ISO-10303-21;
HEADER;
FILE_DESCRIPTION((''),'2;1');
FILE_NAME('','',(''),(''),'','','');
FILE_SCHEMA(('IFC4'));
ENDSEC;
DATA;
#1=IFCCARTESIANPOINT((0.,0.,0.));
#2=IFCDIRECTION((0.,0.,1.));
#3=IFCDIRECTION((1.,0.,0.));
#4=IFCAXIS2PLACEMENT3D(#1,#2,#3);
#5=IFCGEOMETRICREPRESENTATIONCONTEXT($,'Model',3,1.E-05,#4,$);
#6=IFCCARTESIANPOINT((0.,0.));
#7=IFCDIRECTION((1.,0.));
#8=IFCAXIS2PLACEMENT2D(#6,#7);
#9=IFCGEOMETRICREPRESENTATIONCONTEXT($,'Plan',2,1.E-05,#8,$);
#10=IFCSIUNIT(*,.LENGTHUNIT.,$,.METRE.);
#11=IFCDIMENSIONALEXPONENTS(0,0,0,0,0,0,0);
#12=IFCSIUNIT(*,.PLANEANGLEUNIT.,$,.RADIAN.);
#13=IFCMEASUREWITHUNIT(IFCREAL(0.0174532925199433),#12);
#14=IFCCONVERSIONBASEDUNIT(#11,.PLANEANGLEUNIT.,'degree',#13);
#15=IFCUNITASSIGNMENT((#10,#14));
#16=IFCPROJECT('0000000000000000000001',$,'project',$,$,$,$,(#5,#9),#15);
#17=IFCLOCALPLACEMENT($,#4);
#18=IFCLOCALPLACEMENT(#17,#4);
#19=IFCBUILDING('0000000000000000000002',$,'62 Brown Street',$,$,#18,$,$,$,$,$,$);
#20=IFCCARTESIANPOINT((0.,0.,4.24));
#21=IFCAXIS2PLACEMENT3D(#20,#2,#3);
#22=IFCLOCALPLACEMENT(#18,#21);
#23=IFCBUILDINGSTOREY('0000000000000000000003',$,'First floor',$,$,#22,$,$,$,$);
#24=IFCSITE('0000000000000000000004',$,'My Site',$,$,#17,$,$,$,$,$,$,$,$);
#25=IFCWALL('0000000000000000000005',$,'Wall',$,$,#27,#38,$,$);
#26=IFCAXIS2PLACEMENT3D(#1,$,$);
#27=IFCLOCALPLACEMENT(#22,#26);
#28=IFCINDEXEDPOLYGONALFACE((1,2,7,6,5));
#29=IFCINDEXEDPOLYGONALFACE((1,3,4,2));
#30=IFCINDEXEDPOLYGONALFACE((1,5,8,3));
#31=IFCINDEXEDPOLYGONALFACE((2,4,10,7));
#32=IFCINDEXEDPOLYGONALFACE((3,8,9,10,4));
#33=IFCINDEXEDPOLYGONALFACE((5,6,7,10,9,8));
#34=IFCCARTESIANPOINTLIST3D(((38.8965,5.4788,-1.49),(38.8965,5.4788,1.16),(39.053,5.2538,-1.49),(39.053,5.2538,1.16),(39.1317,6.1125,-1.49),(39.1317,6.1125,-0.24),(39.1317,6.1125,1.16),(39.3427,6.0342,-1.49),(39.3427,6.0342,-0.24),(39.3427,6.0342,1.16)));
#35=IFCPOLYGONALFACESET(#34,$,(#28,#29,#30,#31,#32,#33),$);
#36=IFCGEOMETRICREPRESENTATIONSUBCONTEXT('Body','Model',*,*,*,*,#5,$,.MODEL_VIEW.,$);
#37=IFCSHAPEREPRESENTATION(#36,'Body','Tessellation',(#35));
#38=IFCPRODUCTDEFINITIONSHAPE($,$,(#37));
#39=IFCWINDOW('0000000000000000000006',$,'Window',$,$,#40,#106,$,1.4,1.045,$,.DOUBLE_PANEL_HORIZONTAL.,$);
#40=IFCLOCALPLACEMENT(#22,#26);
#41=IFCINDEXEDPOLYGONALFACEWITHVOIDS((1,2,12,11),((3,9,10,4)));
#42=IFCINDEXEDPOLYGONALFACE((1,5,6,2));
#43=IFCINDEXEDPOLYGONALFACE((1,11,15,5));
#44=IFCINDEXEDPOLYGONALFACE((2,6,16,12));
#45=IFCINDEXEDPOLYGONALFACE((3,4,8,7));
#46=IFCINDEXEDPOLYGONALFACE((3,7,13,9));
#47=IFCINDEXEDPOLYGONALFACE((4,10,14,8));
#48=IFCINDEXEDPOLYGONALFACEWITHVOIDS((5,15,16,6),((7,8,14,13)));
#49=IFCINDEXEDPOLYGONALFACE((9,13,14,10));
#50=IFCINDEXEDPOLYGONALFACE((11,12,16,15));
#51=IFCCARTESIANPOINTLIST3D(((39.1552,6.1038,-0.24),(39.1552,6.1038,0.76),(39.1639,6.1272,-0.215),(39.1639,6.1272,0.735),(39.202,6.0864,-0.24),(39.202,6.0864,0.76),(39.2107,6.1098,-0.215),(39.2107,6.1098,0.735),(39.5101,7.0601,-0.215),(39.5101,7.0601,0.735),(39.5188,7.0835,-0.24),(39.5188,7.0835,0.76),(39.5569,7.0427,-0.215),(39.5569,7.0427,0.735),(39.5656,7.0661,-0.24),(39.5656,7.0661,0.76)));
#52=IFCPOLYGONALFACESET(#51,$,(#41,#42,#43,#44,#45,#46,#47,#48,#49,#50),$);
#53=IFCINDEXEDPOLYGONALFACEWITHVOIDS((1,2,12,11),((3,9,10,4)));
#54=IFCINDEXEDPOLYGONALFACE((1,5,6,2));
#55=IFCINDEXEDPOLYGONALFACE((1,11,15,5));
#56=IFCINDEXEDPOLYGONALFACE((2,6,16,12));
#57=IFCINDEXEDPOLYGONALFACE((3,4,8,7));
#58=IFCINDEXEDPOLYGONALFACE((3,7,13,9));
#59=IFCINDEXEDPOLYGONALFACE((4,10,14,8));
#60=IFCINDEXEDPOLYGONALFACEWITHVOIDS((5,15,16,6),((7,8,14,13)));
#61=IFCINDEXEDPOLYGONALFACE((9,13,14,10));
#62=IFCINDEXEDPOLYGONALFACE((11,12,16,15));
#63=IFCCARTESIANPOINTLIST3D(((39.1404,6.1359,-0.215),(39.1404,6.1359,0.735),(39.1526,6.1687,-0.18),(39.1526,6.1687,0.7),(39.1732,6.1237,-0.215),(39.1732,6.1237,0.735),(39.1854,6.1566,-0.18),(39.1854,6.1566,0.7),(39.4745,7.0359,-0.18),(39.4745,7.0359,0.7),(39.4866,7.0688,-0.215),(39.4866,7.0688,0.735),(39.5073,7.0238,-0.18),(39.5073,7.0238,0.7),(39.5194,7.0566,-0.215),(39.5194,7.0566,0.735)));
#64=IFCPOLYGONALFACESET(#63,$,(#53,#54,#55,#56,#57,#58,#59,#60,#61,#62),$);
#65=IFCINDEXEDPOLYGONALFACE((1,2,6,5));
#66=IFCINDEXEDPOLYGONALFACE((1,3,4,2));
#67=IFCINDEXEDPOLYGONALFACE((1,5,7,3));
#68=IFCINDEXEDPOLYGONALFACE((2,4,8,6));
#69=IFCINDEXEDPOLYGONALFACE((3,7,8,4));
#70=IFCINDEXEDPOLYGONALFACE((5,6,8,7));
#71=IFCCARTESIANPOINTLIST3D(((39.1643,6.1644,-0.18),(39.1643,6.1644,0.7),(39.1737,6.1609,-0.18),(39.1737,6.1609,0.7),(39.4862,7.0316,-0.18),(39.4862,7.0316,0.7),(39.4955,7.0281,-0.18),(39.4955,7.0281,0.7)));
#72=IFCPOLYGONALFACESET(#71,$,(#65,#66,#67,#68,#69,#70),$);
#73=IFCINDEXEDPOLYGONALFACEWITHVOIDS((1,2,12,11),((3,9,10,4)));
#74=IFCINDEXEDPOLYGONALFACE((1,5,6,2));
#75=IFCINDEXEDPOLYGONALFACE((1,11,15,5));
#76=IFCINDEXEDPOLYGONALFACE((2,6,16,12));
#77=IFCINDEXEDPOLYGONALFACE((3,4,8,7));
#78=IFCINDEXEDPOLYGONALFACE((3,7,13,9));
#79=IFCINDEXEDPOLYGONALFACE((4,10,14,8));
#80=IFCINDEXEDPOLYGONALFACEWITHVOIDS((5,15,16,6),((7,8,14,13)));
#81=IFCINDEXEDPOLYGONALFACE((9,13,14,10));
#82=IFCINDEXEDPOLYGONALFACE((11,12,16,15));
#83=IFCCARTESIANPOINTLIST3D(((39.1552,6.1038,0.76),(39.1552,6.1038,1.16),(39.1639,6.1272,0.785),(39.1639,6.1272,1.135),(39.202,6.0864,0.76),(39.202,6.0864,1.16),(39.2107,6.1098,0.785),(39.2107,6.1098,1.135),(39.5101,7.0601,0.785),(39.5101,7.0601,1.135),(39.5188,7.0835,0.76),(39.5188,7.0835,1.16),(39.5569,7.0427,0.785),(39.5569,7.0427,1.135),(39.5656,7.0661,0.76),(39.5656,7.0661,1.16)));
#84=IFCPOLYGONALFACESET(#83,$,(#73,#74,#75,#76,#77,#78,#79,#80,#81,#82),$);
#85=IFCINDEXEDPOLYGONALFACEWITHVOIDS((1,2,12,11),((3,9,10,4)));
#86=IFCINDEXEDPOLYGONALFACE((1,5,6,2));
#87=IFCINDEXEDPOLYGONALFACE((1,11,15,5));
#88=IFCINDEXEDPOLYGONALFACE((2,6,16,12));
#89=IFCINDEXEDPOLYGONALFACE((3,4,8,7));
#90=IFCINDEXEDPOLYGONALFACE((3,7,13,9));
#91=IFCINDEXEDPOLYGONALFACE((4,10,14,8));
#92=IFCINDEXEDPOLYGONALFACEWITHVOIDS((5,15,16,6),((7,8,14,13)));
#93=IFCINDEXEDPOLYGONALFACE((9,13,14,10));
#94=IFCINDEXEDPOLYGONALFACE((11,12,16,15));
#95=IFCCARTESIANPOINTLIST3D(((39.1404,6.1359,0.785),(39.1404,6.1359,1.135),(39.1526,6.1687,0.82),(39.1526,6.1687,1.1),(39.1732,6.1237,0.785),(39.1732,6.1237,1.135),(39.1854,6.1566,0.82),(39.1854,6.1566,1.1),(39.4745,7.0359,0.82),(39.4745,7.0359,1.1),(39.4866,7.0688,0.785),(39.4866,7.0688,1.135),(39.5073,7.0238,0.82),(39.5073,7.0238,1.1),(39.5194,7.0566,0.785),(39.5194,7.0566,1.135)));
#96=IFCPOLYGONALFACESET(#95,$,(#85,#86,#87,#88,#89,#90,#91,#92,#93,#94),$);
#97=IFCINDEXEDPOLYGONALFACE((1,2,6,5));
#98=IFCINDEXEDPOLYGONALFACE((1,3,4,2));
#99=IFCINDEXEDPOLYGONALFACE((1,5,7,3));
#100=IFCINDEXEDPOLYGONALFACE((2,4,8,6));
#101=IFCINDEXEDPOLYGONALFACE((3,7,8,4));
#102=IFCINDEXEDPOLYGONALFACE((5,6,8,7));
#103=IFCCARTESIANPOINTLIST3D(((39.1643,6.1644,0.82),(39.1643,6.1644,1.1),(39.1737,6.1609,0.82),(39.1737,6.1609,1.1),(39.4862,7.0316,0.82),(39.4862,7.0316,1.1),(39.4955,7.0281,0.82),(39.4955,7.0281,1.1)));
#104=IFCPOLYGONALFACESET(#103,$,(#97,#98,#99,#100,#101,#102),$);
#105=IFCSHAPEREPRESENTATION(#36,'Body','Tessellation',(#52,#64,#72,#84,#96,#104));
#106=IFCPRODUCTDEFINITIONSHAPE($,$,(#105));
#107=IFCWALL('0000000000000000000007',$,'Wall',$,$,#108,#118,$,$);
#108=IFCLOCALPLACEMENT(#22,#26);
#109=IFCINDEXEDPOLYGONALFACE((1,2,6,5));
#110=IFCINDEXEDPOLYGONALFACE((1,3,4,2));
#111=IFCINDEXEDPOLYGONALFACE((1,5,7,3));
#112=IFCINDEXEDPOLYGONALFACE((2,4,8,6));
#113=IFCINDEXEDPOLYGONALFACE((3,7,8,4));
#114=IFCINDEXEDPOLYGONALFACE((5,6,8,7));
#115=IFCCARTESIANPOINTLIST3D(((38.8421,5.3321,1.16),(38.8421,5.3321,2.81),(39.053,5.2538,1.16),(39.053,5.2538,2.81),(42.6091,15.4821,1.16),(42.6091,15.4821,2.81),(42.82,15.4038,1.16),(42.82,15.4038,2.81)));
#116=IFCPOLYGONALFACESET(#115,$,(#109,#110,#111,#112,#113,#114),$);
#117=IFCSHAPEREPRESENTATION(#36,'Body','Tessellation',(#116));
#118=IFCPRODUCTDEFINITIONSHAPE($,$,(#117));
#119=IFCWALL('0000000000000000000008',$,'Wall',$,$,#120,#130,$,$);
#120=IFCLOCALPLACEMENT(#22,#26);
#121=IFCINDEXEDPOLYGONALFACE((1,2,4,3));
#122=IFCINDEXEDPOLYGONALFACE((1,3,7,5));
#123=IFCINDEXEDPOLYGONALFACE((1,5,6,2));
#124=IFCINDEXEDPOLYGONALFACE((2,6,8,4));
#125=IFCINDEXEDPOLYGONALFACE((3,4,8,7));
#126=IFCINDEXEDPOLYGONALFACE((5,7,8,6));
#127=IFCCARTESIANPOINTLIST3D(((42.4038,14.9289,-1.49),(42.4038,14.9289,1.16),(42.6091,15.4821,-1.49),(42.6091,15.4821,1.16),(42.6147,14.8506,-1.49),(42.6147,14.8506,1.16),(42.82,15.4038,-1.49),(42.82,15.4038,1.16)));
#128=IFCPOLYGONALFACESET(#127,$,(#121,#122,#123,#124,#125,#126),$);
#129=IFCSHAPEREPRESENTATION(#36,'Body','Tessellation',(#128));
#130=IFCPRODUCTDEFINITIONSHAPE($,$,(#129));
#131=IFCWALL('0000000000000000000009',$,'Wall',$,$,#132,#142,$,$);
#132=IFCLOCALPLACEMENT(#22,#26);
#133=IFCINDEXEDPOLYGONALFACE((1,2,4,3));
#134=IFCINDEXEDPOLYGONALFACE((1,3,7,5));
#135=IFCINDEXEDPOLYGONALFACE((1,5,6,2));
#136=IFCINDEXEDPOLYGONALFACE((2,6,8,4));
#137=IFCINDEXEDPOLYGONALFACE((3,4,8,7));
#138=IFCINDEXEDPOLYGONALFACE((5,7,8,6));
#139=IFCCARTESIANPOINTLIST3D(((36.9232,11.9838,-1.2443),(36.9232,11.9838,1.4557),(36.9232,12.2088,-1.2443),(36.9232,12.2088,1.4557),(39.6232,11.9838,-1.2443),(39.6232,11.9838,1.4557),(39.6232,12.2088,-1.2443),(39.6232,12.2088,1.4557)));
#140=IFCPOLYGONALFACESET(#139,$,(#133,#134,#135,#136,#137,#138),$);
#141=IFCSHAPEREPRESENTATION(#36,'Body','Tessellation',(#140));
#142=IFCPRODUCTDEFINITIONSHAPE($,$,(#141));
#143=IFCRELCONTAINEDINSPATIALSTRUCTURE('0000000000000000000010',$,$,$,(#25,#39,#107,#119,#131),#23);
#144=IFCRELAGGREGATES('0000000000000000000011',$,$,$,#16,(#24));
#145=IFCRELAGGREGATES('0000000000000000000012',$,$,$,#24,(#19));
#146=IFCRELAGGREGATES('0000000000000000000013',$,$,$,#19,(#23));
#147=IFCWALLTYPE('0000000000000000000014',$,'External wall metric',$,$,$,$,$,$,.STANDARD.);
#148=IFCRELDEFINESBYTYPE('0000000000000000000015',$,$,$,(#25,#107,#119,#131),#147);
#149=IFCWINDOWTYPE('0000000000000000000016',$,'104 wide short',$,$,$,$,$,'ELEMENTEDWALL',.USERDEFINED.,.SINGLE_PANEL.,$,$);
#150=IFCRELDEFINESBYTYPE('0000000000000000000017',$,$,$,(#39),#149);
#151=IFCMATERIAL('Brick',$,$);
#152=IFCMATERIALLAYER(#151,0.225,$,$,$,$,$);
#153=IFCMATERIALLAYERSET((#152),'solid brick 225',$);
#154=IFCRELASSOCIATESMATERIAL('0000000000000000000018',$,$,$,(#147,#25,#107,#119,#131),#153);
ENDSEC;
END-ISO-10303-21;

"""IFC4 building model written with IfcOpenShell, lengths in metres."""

from ifc_helpers import new_model, entity, si_unit, converted_unit, frame, origin_with_axes, origin_2d_with_axis, place, context, subcontext, project, spatial, line, indexed_curve, outline, extrude, clip, halfspace, shape, source, transform, mapped, material, layer, layer_set, layer_usage, type_object, type_shapes, element, fill, save


model = new_model("IFC4")

# Units and contexts
model_context = context("Model", 3, precision=1e-05, world=origin_with_axes())
plan_context = context("Plan", 2, precision=1e-05, world=origin_2d_with_axis())
body_context_1 = subcontext(model_context, "Body", "Model", "MODEL_VIEW")
body_context_2 = subcontext(plan_context, "Body", "Plan", "PLAN_VIEW")
ifc_project = project(units=[si_unit("LENGTHUNIT", "METRE"), converted_unit("PLANEANGLEUNIT", "degree", entity("IfcReal", 0.0174532925199433), si_unit("PLANEANGLEUNIT", "RADIAN"), dimensions=[0, 0, 0, 0, 0, 0, 0])], contexts=[model_context, plan_context])

# Site, building, storey
site_placement = place(None, origin_with_axes())
site = spatial("IfcSite", under=ifc_project, at=site_placement, Name="My Site")
building_placement = place(site_placement, origin_with_axes())
building = spatial("IfcBuilding", under=site, at=building_placement, Name="62 Brown Street")
storey_placement = place(building_placement, frame((0.0, 0.0, 4.24), z_axis=(0.0, 0.0, 1.0), x_axis=(1.0, 0.0, 0.0)))
storey = spatial("IfcBuildingStorey", under=building, at=storey_placement, Name="First floor")

# Shared definitions
ifc_material_1 = material(Name="Brick")
ifc_layer_1 = layer(ifc_material_1, 0.225)
ifc_layer_set_1 = layer_set([ifc_layer_1], Name="solid brick 225")
wall_type_1 = type_object("IfcWallType", Name="External wall metric", PredefinedType="STANDARD", material=ifc_layer_set_1)

# Wall, opening, window
ifc_layer_usage_1 = layer_usage(ifc_layer_set_1, "AXIS2", "POSITIVE", 0.0)
wall_1_placement = place(storey_placement, frame((39.024, 5.1755, -1.49), z_axis=(0.0, 0.0, 1.0), x_axis=(0.347944, 0.937515, 0.0)))
wall_1 = element("IfcWall", 1, at=wall_1_placement, inside=storey, type_object=wall_type_1, material=ifc_layer_usage_1, Name="Wall", context=body_context_1, shape_type="Clipping", body=[
    clip(extrude(outline(indexed_curve([(0.0, 0.0), (0.0, 0.225), (0.9159, 0.225), (0.9159, 0.0), (0.0, 0.0)], self_intersect=False)), origin_with_axes(), (0.0, 0.0, 1.0), 2.65), halfspace(frame((0.0835, 0.0, -2.75), z_axis=(-0.596248, 0.414701, 0.0), x_axis=(0.156491, 0.224999, 0.0)), False)),
])
shared_shape_1 = source(origin_with_axes(), body_context_1, "Body", "SweptSolid", [
    extrude(outline(indexed_curve([(0.0, 0.0), (1.045, 0.0), (1.045, 1.4), (0.0, 1.4)], segments=[line(1, 2, 3, 4, 1)])), frame((0.0, -0.1, 0.0), z_axis=(0.0, -1.0, 0.0), x_axis=(1.0, 0.0, 0.0)), (0.0, 0.0, -1.0), 0.425),
])
opening_1_placement = place(wall_1_placement, frame((0.9159, 0.0, 1.25), z_axis=(0.0, 0.0, 1.0), x_axis=(1.0, 0.0, 0.0)))
opening_1 = element("IfcOpeningElement", 2, at=opening_1_placement, cuts=wall_1, PredefinedType="OPENING", context=body_context_1, shape_type="MappedRepresentation", body=[
    mapped(shared_shape_1, transform((0.0, 0.0, 0.0), x_axis=(1.0, 0.0, 0.0), y_axis=(0.0, 1.0, 0.0), z_axis=(0.0, 0.0, 1.0), scale=1.0)),
])
window_type_1 = type_object("IfcWindowType", Name="104 wide short", ElementType="ELEMENTEDWALL", PartitioningType="SINGLE_PANEL", PredefinedType="USERDEFINED")
shared_shape_2 = source(origin_with_axes(), body_context_1, "Body", "SweptSolid", [
    extrude(outline(indexed_curve([(0.0, 0.0), (1.045, 0.0), (1.045, 1.0), (0.0, 1.0)], segments=[line(1, 2, 3, 4, 1)]), holes=[indexed_curve([(0.025, 0.025), (1.02, 0.025), (1.02, 0.975), (0.025, 0.975)], segments=[line(1, 2, 3, 4, 1)])]), frame((0.0, 0.15, 0.0), z_axis=(0.0, -1.0, 0.0), x_axis=(1.0, 0.0, 0.0)), (0.0, 0.0, -1.0), 0.05),
    extrude(outline(indexed_curve([(0.0, 0.0), (0.995, 0.0), (0.995, 0.95), (0.0, 0.95)], segments=[line(1, 2, 3, 4, 1)]), holes=[indexed_curve([(0.035, 0.035), (0.96, 0.035), (0.96, 0.915), (0.035, 0.915)], segments=[line(1, 2, 3, 4, 1)])]), frame((0.025, 0.19, 0.025), z_axis=(0.0, -1.0, 0.0), x_axis=(1.0, 0.0, 0.0)), (0.0, 0.0, -1.0), 0.035),
    extrude(outline(indexed_curve([(0.035, 0.035), (0.96, 0.035), (0.96, 0.915), (0.035, 0.915)], segments=[line(1, 2, 3, 4, 1)])), frame((0.025, 0.2025, 0.025), z_axis=(0.0, -1.0, 0.0), x_axis=(1.0, 0.0, 0.0)), (0.0, 0.0, -1.0), 0.01),
    extrude(outline(indexed_curve([(0.0, 0.0), (1.045, 0.0), (1.045, 0.4), (0.0, 0.4)], segments=[line(1, 2, 3, 4, 1)]), holes=[indexed_curve([(0.025, 0.025), (1.02, 0.025), (1.02, 0.375), (0.025, 0.375)], segments=[line(1, 2, 3, 4, 1)])]), frame((0.0, 0.15, 1.0), z_axis=(0.0, -1.0, 0.0), x_axis=(1.0, 0.0, 0.0)), (0.0, 0.0, -1.0), 0.05),
    extrude(outline(indexed_curve([(0.0, 0.0), (0.995, 0.0), (0.995, 0.35), (0.0, 0.35)], segments=[line(1, 2, 3, 4, 1)]), holes=[indexed_curve([(0.035, 0.035), (0.96, 0.035), (0.96, 0.315), (0.035, 0.315)], segments=[line(1, 2, 3, 4, 1)])]), frame((0.025, 0.19, 1.025), z_axis=(0.0, -1.0, 0.0), x_axis=(1.0, 0.0, 0.0)), (0.0, 0.0, -1.0), 0.035),
    extrude(outline(indexed_curve([(0.035, 0.035), (0.96, 0.035), (0.96, 0.315), (0.035, 0.315)], segments=[line(1, 2, 3, 4, 1)])), frame((0.025, 0.2025, 1.025), z_axis=(0.0, -1.0, 0.0), x_axis=(1.0, 0.0, 0.0)), (0.0, 0.0, -1.0), 0.01),
])
shared_shape_3 = source(origin_with_axes(), body_context_2, "Body", "Curve2D", [
    entity("IfcIndexedPolyCurve", entity("IfcCartesianPointList2D", [[0.025, 0.15], [1.02, 0.15]])),
    entity("IfcIndexedPolyCurve", entity("IfcCartesianPointList2D", [[0.0, 0.2], [0.025, 0.2], [0.025, 0.15], [0.0, 0.15]]), [entity("IfcLineIndex", [1, 2, 3, 4, 1])]),
    entity("IfcIndexedPolyCurve", entity("IfcCartesianPointList2D", [[1.045, 0.2], [1.02, 0.2], [1.02, 0.15], [1.045, 0.15]]), [entity("IfcLineIndex", [1, 2, 3, 4, 1])]),
    entity("IfcIndexedPolyCurve", entity("IfcCartesianPointList2D", [[0.025, 0.19], [0.06, 0.19], [0.06, 0.225], [0.025, 0.225]]), [entity("IfcLineIndex", [1, 2, 3, 4, 1])]),
    entity("IfcIndexedPolyCurve", entity("IfcCartesianPointList2D", [[1.02, 0.19], [0.985, 0.19], [0.985, 0.225], [1.02, 0.225]]), [entity("IfcLineIndex", [1, 2, 3, 4, 1])]),
    entity("IfcIndexedPolyCurve", entity("IfcCartesianPointList2D", [[0.06, 0.19], [0.985, 0.19]])),
    entity("IfcIndexedPolyCurve", entity("IfcCartesianPointList2D", [[0.06, 0.225], [0.985, 0.225]])),
    entity("IfcIndexedPolyCurve", entity("IfcCartesianPointList2D", [[0.06, 0.2075], [0.985, 0.2075]])),
])
type_shapes(window_type_1, [shared_shape_2, shared_shape_3])
window_1_placement = place(opening_1_placement, frame((0.0, 0.0, 0.0), z_axis=(0.0, 0.0, 1.0), x_axis=(1.0, 0.0, 0.0)))
window_1 = element("IfcWindow", 3, at=window_1_placement, inside=storey, type_object=window_type_1, Name="Window", OverallHeight=1.4, OverallWidth=1.045, PartitioningType="DOUBLE_PANEL_HORIZONTAL", shapes=[
    shape(body_context_1, "Body", "MappedRepresentation", [mapped(shared_shape_2, transform((0.0, 0.0, 0.0), x_axis=(1.0, 0.0, 0.0), y_axis=(0.0, 1.0, 0.0), z_axis=(0.0, 0.0, 1.0), scale=1.0))]),
    shape(body_context_2, "Body", "MappedRepresentation", [mapped(shared_shape_3, transform((0.0, 0.0, 0.0), x_axis=(1.0, 0.0, 0.0), y_axis=(0.0, 1.0, 0.0), z_axis=(0.0, 0.0, 1.0), scale=1.0))]),
])
fill(opening_1, window_1)

# Walls
ifc_layer_usage_2 = layer_usage(ifc_layer_set_1, "AXIS2", "POSITIVE", 0.0)
wall_2_placement = place(storey_placement, frame((39.053, 5.2538, 1.16), z_axis=(0.0, 0.0, 1.0), x_axis=(0.347944, 0.937515, 0.0)))
element("IfcWall", 4, at=wall_2_placement, inside=storey, type_object=wall_type_1, material=ifc_layer_usage_2, Name="Wall", context=body_context_1, shape_type="SweptSolid", body=[
    extrude(outline(indexed_curve([(0.0, 0.0), (0.0, 0.225), (10.8265, 0.225), (10.8265, 0.0), (0.0, 0.0)], self_intersect=False)), origin_with_axes(), (0.0, 0.0, 1.0), 1.65),
])
ifc_layer_usage_3 = layer_usage(ifc_layer_set_1, "AXIS2", "POSITIVE", 0.0)
wall_3_placement = place(storey_placement, frame((42.6147, 14.8506, -1.49), z_axis=(0.0, 0.0, 1.0), x_axis=(0.347944, 0.937515, 0.0)))
element("IfcWall", 5, at=wall_3_placement, inside=storey, type_object=wall_type_1, material=ifc_layer_usage_3, Name="Wall", context=body_context_1, shape_type="SweptSolid", body=[
    extrude(outline(indexed_curve([(0.0, 0.0), (0.0, 0.225), (0.5901, 0.225), (0.5901, 0.0), (0.0, 0.0)], self_intersect=False)), origin_with_axes(), (0.0, 0.0, 1.0), 2.65),
])
ifc_layer_usage_4 = layer_usage(ifc_layer_set_1, "AXIS2", "POSITIVE", 0.0)
wall_4_placement = place(storey_placement, frame((36.9232, 11.9838, -1.2443), z_axis=(0.0, 0.0, 1.0), x_axis=(1.0, 0.0, 0.0)))
element("IfcWall", 6, at=wall_4_placement, inside=storey, type_object=wall_type_1, material=ifc_layer_usage_4, Name="Wall", context=body_context_1, shape_type="SweptSolid", body=[
    extrude(outline(indexed_curve([(0.0, 0.0), (0.0, 0.225), (2.7, 0.225), (2.7, 0.0), (0.0, 0.0)], self_intersect=False)), origin_with_axes(), (0.0, 0.0, 1.0), 2.7),
])

save(model, "model.ifc")
